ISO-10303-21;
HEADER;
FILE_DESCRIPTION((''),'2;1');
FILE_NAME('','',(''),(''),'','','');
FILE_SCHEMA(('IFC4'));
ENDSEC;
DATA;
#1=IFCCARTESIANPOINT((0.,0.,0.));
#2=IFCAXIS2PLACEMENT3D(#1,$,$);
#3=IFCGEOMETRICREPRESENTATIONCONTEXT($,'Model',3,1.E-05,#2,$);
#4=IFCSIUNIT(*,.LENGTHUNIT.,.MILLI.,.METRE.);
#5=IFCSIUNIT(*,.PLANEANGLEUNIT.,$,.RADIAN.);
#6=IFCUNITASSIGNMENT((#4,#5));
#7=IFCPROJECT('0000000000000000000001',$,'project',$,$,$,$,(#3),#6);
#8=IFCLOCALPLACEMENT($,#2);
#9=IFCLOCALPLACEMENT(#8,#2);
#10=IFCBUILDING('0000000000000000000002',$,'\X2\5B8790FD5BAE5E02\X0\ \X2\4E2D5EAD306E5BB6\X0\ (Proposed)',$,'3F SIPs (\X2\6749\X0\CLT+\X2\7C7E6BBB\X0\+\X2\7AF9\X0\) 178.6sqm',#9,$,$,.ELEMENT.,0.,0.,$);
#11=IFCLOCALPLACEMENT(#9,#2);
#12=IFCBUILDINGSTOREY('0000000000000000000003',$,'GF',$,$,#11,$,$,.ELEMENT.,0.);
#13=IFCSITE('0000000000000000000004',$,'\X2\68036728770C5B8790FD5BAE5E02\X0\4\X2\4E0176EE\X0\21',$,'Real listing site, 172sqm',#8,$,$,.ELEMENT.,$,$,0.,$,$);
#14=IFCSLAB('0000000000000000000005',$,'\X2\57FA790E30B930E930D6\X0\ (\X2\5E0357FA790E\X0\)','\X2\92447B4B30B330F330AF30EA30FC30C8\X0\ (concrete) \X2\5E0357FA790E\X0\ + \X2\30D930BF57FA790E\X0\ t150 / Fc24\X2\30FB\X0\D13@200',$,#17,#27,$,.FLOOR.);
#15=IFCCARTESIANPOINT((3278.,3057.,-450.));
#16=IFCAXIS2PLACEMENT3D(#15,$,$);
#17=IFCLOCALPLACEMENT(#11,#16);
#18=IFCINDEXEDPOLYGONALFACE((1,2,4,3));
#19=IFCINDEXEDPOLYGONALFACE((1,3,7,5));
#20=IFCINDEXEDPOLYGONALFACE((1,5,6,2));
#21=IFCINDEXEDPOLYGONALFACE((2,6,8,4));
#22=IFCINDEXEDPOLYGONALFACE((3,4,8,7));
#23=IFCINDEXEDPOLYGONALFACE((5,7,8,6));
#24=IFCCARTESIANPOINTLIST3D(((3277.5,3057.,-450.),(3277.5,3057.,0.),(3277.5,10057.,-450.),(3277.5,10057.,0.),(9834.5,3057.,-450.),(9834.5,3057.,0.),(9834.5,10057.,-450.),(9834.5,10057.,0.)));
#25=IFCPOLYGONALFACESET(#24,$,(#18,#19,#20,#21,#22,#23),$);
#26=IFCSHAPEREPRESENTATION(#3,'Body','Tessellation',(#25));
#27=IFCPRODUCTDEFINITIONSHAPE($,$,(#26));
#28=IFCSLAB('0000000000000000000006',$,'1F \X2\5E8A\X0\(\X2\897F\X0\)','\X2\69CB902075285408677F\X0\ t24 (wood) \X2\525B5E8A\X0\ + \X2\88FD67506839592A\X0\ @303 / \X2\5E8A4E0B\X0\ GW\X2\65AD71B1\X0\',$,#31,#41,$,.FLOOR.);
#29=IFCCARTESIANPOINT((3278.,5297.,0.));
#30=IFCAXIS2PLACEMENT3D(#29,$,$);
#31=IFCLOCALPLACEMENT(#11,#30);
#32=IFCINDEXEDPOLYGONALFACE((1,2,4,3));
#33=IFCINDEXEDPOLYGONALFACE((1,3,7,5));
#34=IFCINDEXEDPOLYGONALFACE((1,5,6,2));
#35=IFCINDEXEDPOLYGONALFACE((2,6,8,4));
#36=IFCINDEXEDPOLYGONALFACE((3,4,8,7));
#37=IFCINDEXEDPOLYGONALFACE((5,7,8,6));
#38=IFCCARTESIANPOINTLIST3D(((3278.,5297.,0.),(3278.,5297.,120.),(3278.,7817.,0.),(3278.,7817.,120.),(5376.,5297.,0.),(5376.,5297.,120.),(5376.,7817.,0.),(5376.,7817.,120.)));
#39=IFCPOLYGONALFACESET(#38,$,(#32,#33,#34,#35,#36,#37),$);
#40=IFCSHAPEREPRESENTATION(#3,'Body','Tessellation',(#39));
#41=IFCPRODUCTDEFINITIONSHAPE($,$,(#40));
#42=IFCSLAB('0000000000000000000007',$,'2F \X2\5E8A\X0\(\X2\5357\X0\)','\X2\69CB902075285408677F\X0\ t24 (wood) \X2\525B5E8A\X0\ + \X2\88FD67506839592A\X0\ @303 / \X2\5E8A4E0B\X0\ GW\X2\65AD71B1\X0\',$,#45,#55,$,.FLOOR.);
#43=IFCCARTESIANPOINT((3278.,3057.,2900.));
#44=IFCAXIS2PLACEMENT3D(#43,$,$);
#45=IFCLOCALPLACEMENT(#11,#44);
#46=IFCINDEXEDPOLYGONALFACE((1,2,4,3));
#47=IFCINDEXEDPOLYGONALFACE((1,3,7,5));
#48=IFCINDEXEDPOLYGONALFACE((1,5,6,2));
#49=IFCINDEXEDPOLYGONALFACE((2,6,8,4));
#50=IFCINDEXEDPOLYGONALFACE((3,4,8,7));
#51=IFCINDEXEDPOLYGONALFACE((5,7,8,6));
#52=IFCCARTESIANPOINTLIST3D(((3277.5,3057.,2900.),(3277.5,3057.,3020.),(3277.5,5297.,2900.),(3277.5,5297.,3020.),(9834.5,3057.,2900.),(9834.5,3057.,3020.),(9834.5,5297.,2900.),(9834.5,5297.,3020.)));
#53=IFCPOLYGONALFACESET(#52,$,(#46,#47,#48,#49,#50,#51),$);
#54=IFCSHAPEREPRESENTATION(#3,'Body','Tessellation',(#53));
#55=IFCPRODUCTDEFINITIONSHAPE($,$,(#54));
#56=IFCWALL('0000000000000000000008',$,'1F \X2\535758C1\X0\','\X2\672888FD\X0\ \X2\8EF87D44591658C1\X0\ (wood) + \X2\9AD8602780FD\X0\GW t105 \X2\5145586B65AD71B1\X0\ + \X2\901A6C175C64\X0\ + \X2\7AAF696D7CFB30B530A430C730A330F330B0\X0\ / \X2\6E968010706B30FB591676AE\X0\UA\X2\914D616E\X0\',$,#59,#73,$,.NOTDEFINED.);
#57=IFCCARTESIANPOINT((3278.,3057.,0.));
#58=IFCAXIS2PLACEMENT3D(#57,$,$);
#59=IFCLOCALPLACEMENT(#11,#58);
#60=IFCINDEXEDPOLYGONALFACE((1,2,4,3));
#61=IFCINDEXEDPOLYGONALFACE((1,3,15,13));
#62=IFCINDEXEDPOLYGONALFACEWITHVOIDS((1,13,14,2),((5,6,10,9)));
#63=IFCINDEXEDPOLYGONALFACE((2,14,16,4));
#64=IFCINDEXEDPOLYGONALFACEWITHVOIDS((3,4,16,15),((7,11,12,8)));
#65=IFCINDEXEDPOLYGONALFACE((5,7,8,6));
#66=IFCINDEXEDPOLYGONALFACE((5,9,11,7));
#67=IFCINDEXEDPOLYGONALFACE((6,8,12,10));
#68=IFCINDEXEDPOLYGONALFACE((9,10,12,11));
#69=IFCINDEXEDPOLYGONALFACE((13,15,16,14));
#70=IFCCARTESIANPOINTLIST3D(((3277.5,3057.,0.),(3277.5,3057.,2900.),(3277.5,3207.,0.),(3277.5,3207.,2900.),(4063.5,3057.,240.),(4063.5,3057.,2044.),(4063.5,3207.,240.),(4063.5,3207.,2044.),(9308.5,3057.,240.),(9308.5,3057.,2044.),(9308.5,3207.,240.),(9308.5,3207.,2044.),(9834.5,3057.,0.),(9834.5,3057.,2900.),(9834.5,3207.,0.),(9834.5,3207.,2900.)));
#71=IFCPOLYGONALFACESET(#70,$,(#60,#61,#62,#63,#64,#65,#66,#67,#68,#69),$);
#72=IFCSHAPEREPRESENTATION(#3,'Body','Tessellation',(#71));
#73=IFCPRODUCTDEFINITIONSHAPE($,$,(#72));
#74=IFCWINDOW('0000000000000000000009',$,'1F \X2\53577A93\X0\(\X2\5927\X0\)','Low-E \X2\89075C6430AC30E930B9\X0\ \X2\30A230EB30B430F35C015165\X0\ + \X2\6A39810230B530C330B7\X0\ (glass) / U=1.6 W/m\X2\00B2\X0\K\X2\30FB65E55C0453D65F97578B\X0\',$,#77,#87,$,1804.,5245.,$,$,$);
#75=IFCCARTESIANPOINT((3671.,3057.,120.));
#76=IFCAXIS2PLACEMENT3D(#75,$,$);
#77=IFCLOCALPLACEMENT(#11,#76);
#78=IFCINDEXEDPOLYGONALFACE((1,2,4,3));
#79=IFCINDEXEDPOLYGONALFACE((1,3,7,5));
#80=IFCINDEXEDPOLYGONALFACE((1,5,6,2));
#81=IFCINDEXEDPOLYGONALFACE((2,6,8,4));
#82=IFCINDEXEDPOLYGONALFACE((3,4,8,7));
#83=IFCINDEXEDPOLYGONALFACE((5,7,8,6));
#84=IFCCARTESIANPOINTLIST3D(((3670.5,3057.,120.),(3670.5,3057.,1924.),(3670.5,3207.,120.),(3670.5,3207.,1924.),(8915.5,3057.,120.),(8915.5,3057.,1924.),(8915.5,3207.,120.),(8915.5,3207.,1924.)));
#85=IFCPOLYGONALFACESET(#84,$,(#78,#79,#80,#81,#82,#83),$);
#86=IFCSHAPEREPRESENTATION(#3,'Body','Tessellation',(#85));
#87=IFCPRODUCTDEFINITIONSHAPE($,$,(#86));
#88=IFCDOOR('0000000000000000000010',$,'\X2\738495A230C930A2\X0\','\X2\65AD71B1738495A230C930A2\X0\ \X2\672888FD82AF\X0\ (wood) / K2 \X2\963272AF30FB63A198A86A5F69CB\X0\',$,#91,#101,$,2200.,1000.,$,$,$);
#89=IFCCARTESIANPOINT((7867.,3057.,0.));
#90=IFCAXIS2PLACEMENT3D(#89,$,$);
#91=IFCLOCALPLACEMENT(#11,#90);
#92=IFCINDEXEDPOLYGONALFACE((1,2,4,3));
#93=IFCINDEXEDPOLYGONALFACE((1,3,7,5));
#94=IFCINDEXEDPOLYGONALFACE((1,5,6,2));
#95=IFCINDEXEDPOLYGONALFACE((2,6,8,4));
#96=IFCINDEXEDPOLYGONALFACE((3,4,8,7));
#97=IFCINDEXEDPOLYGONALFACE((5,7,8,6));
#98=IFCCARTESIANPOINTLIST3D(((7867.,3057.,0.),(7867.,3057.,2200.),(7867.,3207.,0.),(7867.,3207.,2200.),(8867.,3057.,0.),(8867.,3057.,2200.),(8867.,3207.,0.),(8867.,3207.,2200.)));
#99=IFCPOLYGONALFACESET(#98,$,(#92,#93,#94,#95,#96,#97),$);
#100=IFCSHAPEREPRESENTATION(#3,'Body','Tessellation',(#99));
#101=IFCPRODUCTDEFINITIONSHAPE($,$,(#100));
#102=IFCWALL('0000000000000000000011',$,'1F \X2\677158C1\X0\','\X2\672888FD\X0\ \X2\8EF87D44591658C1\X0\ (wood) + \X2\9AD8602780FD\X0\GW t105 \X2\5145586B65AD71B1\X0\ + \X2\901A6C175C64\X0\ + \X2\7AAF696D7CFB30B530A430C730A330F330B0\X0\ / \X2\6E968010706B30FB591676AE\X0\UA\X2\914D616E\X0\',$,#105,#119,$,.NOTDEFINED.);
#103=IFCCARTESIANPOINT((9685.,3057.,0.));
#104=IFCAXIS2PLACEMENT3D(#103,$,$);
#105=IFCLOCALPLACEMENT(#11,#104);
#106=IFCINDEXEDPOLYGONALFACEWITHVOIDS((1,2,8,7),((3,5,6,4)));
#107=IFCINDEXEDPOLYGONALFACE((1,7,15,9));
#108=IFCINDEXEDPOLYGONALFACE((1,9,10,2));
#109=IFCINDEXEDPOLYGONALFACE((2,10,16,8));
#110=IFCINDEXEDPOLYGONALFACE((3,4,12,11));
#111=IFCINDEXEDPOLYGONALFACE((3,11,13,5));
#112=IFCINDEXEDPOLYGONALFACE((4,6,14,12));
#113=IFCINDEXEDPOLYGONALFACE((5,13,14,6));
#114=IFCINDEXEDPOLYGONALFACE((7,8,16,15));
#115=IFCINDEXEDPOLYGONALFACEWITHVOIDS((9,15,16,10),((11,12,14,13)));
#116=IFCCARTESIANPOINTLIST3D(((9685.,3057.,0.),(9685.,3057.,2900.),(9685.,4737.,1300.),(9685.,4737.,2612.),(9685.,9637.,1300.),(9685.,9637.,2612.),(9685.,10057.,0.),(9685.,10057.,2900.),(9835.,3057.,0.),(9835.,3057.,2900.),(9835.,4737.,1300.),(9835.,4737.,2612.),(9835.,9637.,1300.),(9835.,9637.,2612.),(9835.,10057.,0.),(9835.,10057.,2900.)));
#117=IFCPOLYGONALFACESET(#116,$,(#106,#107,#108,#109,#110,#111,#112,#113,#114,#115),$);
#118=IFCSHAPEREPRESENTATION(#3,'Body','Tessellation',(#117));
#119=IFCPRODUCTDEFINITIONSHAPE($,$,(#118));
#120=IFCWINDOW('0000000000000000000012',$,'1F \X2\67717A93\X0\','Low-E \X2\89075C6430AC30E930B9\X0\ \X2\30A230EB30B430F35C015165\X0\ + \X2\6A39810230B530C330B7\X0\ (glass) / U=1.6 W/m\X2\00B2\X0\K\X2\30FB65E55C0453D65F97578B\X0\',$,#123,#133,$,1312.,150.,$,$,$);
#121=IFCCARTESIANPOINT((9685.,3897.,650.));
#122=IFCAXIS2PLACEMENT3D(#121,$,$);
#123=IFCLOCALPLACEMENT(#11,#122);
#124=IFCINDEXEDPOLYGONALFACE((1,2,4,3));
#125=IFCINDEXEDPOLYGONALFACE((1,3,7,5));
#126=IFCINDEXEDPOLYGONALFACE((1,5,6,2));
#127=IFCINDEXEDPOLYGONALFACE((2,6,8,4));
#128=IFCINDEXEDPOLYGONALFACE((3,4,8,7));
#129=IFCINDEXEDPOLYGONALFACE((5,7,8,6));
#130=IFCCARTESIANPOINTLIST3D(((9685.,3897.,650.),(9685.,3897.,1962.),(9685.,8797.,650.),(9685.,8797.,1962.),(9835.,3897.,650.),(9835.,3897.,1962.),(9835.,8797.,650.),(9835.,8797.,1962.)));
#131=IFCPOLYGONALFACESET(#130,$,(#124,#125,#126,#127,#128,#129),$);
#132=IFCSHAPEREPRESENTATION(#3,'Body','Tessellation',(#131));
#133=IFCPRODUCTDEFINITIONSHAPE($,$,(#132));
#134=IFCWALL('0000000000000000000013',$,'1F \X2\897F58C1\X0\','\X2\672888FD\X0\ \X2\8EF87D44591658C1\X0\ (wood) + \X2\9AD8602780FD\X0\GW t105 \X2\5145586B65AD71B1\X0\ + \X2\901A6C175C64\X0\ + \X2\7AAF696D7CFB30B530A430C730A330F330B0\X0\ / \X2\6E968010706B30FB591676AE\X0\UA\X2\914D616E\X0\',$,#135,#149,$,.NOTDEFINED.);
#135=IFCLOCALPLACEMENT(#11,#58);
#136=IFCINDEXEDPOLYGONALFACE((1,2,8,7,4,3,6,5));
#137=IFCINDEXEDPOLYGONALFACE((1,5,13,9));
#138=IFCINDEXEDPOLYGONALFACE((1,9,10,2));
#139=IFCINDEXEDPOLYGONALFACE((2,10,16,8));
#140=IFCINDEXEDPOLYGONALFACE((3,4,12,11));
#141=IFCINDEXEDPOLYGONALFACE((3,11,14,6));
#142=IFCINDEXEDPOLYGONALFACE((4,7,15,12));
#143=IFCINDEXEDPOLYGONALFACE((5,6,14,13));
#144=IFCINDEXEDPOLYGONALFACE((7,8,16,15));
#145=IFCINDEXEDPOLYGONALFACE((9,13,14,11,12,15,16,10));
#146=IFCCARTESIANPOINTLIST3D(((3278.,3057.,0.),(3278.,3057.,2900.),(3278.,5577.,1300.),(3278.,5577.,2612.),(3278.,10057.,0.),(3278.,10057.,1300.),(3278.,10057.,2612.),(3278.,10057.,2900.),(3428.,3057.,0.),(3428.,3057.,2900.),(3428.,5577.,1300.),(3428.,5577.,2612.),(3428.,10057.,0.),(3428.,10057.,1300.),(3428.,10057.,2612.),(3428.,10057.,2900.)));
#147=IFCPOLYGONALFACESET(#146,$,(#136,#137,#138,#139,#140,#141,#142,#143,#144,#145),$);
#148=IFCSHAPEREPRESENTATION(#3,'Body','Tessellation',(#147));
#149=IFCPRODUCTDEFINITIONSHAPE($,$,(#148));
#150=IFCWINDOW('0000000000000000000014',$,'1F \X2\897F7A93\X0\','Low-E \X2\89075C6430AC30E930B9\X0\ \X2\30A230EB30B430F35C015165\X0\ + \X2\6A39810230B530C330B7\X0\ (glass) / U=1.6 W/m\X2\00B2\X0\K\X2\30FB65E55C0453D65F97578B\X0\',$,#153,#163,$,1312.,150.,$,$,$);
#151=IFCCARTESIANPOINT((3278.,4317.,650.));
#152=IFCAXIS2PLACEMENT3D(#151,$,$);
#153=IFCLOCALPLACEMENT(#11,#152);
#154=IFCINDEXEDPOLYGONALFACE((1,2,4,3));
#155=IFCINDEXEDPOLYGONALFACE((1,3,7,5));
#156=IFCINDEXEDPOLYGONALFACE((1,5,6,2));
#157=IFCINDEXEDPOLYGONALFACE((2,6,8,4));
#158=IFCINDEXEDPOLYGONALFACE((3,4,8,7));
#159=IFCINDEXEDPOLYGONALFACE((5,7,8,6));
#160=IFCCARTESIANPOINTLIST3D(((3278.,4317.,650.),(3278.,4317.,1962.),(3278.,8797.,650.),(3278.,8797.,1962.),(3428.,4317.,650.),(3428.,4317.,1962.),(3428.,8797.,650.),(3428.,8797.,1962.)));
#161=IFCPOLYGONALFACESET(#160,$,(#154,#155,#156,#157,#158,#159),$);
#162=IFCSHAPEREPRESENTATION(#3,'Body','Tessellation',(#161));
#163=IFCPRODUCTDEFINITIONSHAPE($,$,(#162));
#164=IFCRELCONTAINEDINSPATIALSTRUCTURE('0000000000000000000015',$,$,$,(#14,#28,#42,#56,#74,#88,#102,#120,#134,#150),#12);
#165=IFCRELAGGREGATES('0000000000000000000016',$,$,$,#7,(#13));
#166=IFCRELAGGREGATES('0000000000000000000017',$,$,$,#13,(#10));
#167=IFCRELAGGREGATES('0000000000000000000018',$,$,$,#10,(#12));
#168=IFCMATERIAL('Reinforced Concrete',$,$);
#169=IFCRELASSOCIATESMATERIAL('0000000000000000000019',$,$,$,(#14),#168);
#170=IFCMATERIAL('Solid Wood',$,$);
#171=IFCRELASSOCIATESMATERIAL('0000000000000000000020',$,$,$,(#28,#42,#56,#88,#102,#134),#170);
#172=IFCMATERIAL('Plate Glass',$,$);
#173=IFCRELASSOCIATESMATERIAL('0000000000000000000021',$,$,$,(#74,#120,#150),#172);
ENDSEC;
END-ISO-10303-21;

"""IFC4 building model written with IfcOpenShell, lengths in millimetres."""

from ifc_helpers import new_model, si_unit, frame, frame_2d, origin, place, context, project, spatial, rectangle, extrude, material, element, fill, save


model = new_model("IFC4")

# Units and contexts
model_context = context("Model", 3, precision=1e-05, world=origin())
ifc_project = project(units=[si_unit("LENGTHUNIT", "METRE", prefix="MILLI"), si_unit("PLANEANGLEUNIT", "RADIAN")], contexts=[model_context])

# Site, building, storey
site_placement = place(None, origin())
site = spatial("IfcSite", under=ifc_project, at=site_placement, Name="栃木県宇都宮市4丁目21", ObjectType="Real listing site, 172sqm", CompositionType="ELEMENT", RefElevation=0.0)
building_placement = place(site_placement, origin())
building = spatial("IfcBuilding", under=site, at=building_placement, Name="宇都宮市 中庭の家 (Proposed)", ObjectType="3F SIPs (杉CLT+籾殻+竹) 178.6sqm", CompositionType="ELEMENT", ElevationOfRefHeight=0.0, ElevationOfTerrain=0.0)
storey_placement = place(building_placement, origin())
storey = spatial("IfcBuildingStorey", under=building, at=storey_placement, Name="GF", CompositionType="ELEMENT", Elevation=0.0)

# Slabs
ifc_material_1 = material(Name="Reinforced Concrete")
slab_1_placement = place(storey_placement, frame((3278.0, 3057.0, -450.0)))
element("IfcSlab", 1, at=slab_1_placement, inside=storey, material=ifc_material_1, Name="基礎スラブ (布基礎)", Description="鉄筋コンクリート (concrete) 布基礎 + ベタ基礎 t150 / Fc24・D13@200", PredefinedType="FLOOR", context=model_context, shape_type="SweptSolid", body=[
    extrude(rectangle(XDim=6557.0, YDim=7000.0, at=frame_2d((3278.0, 3500.0))), frame((3278.0, 3057.0, -450.0)), (0.0, 0.0, 1.0), 450.0),
])
ifc_material_2 = material(Name="Solid Wood")
slab_2_placement = place(storey_placement, frame((3278.0, 5297.0, 0.0)))
element("IfcSlab", 2, at=slab_2_placement, inside=storey, material=ifc_material_2, Name="1F 床(西)", Description="構造用合板 t24 (wood) 剛床 + 製材根太 @303 / 床下 GW断熱", PredefinedType="FLOOR", context=model_context, shape_type="SweptSolid", body=[
    extrude(rectangle(XDim=2098.0, YDim=2520.0, at=frame_2d((1049.0, 1260.0))), frame((3278.0, 5297.0, 0.0)), (0.0, 0.0, 1.0), 120.0),
])
slab_3_placement = place(storey_placement, frame((3278.0, 3057.0, 2900.0)))
element("IfcSlab", 3, at=slab_3_placement, inside=storey, material=ifc_material_2, Name="2F 床(南)", Description="構造用合板 t24 (wood) 剛床 + 製材根太 @303 / 床下 GW断熱", PredefinedType="FLOOR", context=model_context, shape_type="SweptSolid", body=[
    extrude(rectangle(XDim=6557.0, YDim=2240.0, at=frame_2d((3278.0, 1120.0))), frame((3278.0, 3057.0, 2900.0)), (0.0, 0.0, 1.0), 120.0),
])

# Wall, openings, window, door
wall_1_placement = place(storey_placement, frame((3278.0, 3057.0, 0.0)))
wall_1 = element("IfcWall", 4, at=wall_1_placement, inside=storey, material=ifc_material_2, Name="1F 南壁", Description="木製 軸組外壁 (wood) + 高性能GW t105 充填断熱 + 通気層 + 窯業系サイディング / 準耐火・外皮UA配慮", PredefinedType="NOTDEFINED", context=model_context, shape_type="SweptSolid", body=[
    extrude(rectangle(XDim=6557.0, YDim=150.0, at=frame_2d((3278.0, 75.0))), frame((3278.0, 3057.0, 0.0)), (0.0, 0.0, 1.0), 2900.0),
])
opening_1_placement = place(storey_placement, frame((3671.0, 3057.0, 120.0)))
opening_1 = element("IfcOpeningElement", 5, at=opening_1_placement, cuts=wall_1, PredefinedType="NOTDEFINED", context=model_context, shape_type="SweptSolid", body=[
    extrude(rectangle(XDim=5245.0, YDim=150.0, at=frame_2d((2622.0, 75.0))), frame((3671.0, 3057.0, 120.0)), (0.0, 0.0, 1.0), 1804.0),
])
opening_2_placement = place(storey_placement, frame((7867.0, 3057.0, 0.0)))
opening_2 = element("IfcOpeningElement", 6, at=opening_2_placement, cuts=wall_1, PredefinedType="NOTDEFINED", context=model_context, shape_type="SweptSolid", body=[
    extrude(rectangle(XDim=1000.0, YDim=150.0, at=frame_2d((500.0, 75.0))), frame((7867.0, 3057.0, 0.0)), (0.0, 0.0, 1.0), 2200.0),
])
ifc_material_3 = material(Name="Plate Glass")
window_1_placement = place(storey_placement, frame((3671.0, 3057.0, 120.0)))
window_1 = element("IfcWindow", 7, at=window_1_placement, inside=storey, material=ifc_material_3, Name="1F 南窓(大)", Description="Low-E 複層ガラス アルゴン封入 + 樹脂サッシ (glass) / U=1.6 W/m²K・日射取得型", OverallHeight=1804.0, OverallWidth=5245.0, context=model_context, shape_type="SweptSolid", body=[
    extrude(rectangle(XDim=5245.0, YDim=150.0, at=frame_2d((2622.0, 75.0))), frame((3671.0, 3057.0, 120.0)), (0.0, 0.0, 1.0), 1804.0),
])
fill(opening_1, window_1)
door_placement = place(storey_placement, frame((7867.0, 3057.0, 0.0)))
door = element("IfcDoor", 8, at=door_placement, inside=storey, material=ifc_material_2, Name="玄関ドア", Description="断熱玄関ドア 木製芯 (wood) / K2 防犯・採風機構", OverallHeight=2200.0, OverallWidth=1000.0, context=model_context, shape_type="SweptSolid", body=[
    extrude(rectangle(XDim=1000.0, YDim=150.0, at=frame_2d((500.0, 75.0))), frame((7867.0, 3057.0, 0.0)), (0.0, 0.0, 1.0), 2200.0),
])
fill(opening_2, door)

# Walls, openings, windows
wall_2_placement = place(storey_placement, frame((9685.0, 3057.0, 0.0)))
wall_2 = element("IfcWall", 9, at=wall_2_placement, inside=storey, material=ifc_material_2, Name="1F 東壁", Description="木製 軸組外壁 (wood) + 高性能GW t105 充填断熱 + 通気層 + 窯業系サイディング / 準耐火・外皮UA配慮", PredefinedType="NOTDEFINED", context=model_context, shape_type="SweptSolid", body=[
    extrude(rectangle(XDim=150.0, YDim=7000.0, at=frame_2d((75.0, 3500.0))), frame((9685.0, 3057.0, 0.0)), (0.0, 0.0, 1.0), 2900.0),
])
opening_3_placement = place(storey_placement, frame((9685.0, 3897.0, 650.0)))
opening_3 = element("IfcOpeningElement", 10, at=opening_3_placement, cuts=wall_2, PredefinedType="NOTDEFINED", context=model_context, shape_type="SweptSolid", body=[
    extrude(rectangle(XDim=150.0, YDim=4900.0, at=frame_2d((75.0, 2450.0))), frame((9685.0, 3897.0, 650.0)), (0.0, 0.0, 1.0), 1312.0),
])
window_2_placement = place(storey_placement, frame((9685.0, 3897.0, 650.0)))
window_2 = element("IfcWindow", 11, at=window_2_placement, inside=storey, material=ifc_material_3, Name="1F 東窓", Description="Low-E 複層ガラス アルゴン封入 + 樹脂サッシ (glass) / U=1.6 W/m²K・日射取得型", OverallHeight=1312.0, OverallWidth=150.0, context=model_context, shape_type="SweptSolid", body=[
    extrude(rectangle(XDim=150.0, YDim=4900.0, at=frame_2d((75.0, 2450.0))), frame((9685.0, 3897.0, 650.0)), (0.0, 0.0, 1.0), 1312.0),
])
fill(opening_3, window_2)
wall_3_placement = place(storey_placement, frame((3278.0, 3057.0, 0.0)))
wall_3 = element("IfcWall", 12, at=wall_3_placement, inside=storey, material=ifc_material_2, Name="1F 西壁", Description="木製 軸組外壁 (wood) + 高性能GW t105 充填断熱 + 通気層 + 窯業系サイディング / 準耐火・外皮UA配慮", PredefinedType="NOTDEFINED", context=model_context, shape_type="SweptSolid", body=[
    extrude(rectangle(XDim=150.0, YDim=7000.0, at=frame_2d((75.0, 3500.0))), frame((3278.0, 3057.0, 0.0)), (0.0, 0.0, 1.0), 2900.0),
])
opening_4_placement = place(storey_placement, frame((3278.0, 4317.0, 650.0)))
opening_4 = element("IfcOpeningElement", 13, at=opening_4_placement, cuts=wall_3, PredefinedType="NOTDEFINED", context=model_context, shape_type="SweptSolid", body=[
    extrude(rectangle(XDim=150.0, YDim=4480.0, at=frame_2d((75.0, 2240.0))), frame((3278.0, 4317.0, 650.0)), (0.0, 0.0, 1.0), 1312.0),
])
window_3_placement = place(storey_placement, frame((3278.0, 4317.0, 650.0)))
window_3 = element("IfcWindow", 14, at=window_3_placement, inside=storey, material=ifc_material_3, Name="1F 西窓", Description="Low-E 複層ガラス アルゴン封入 + 樹脂サッシ (glass) / U=1.6 W/m²K・日射取得型", OverallHeight=1312.0, OverallWidth=150.0, context=model_context, shape_type="SweptSolid", body=[
    extrude(rectangle(XDim=150.0, YDim=4480.0, at=frame_2d((75.0, 2240.0))), frame((3278.0, 4317.0, 650.0)), (0.0, 0.0, 1.0), 1312.0),
])
fill(opening_4, window_3)

save(model, "model.ifc")
